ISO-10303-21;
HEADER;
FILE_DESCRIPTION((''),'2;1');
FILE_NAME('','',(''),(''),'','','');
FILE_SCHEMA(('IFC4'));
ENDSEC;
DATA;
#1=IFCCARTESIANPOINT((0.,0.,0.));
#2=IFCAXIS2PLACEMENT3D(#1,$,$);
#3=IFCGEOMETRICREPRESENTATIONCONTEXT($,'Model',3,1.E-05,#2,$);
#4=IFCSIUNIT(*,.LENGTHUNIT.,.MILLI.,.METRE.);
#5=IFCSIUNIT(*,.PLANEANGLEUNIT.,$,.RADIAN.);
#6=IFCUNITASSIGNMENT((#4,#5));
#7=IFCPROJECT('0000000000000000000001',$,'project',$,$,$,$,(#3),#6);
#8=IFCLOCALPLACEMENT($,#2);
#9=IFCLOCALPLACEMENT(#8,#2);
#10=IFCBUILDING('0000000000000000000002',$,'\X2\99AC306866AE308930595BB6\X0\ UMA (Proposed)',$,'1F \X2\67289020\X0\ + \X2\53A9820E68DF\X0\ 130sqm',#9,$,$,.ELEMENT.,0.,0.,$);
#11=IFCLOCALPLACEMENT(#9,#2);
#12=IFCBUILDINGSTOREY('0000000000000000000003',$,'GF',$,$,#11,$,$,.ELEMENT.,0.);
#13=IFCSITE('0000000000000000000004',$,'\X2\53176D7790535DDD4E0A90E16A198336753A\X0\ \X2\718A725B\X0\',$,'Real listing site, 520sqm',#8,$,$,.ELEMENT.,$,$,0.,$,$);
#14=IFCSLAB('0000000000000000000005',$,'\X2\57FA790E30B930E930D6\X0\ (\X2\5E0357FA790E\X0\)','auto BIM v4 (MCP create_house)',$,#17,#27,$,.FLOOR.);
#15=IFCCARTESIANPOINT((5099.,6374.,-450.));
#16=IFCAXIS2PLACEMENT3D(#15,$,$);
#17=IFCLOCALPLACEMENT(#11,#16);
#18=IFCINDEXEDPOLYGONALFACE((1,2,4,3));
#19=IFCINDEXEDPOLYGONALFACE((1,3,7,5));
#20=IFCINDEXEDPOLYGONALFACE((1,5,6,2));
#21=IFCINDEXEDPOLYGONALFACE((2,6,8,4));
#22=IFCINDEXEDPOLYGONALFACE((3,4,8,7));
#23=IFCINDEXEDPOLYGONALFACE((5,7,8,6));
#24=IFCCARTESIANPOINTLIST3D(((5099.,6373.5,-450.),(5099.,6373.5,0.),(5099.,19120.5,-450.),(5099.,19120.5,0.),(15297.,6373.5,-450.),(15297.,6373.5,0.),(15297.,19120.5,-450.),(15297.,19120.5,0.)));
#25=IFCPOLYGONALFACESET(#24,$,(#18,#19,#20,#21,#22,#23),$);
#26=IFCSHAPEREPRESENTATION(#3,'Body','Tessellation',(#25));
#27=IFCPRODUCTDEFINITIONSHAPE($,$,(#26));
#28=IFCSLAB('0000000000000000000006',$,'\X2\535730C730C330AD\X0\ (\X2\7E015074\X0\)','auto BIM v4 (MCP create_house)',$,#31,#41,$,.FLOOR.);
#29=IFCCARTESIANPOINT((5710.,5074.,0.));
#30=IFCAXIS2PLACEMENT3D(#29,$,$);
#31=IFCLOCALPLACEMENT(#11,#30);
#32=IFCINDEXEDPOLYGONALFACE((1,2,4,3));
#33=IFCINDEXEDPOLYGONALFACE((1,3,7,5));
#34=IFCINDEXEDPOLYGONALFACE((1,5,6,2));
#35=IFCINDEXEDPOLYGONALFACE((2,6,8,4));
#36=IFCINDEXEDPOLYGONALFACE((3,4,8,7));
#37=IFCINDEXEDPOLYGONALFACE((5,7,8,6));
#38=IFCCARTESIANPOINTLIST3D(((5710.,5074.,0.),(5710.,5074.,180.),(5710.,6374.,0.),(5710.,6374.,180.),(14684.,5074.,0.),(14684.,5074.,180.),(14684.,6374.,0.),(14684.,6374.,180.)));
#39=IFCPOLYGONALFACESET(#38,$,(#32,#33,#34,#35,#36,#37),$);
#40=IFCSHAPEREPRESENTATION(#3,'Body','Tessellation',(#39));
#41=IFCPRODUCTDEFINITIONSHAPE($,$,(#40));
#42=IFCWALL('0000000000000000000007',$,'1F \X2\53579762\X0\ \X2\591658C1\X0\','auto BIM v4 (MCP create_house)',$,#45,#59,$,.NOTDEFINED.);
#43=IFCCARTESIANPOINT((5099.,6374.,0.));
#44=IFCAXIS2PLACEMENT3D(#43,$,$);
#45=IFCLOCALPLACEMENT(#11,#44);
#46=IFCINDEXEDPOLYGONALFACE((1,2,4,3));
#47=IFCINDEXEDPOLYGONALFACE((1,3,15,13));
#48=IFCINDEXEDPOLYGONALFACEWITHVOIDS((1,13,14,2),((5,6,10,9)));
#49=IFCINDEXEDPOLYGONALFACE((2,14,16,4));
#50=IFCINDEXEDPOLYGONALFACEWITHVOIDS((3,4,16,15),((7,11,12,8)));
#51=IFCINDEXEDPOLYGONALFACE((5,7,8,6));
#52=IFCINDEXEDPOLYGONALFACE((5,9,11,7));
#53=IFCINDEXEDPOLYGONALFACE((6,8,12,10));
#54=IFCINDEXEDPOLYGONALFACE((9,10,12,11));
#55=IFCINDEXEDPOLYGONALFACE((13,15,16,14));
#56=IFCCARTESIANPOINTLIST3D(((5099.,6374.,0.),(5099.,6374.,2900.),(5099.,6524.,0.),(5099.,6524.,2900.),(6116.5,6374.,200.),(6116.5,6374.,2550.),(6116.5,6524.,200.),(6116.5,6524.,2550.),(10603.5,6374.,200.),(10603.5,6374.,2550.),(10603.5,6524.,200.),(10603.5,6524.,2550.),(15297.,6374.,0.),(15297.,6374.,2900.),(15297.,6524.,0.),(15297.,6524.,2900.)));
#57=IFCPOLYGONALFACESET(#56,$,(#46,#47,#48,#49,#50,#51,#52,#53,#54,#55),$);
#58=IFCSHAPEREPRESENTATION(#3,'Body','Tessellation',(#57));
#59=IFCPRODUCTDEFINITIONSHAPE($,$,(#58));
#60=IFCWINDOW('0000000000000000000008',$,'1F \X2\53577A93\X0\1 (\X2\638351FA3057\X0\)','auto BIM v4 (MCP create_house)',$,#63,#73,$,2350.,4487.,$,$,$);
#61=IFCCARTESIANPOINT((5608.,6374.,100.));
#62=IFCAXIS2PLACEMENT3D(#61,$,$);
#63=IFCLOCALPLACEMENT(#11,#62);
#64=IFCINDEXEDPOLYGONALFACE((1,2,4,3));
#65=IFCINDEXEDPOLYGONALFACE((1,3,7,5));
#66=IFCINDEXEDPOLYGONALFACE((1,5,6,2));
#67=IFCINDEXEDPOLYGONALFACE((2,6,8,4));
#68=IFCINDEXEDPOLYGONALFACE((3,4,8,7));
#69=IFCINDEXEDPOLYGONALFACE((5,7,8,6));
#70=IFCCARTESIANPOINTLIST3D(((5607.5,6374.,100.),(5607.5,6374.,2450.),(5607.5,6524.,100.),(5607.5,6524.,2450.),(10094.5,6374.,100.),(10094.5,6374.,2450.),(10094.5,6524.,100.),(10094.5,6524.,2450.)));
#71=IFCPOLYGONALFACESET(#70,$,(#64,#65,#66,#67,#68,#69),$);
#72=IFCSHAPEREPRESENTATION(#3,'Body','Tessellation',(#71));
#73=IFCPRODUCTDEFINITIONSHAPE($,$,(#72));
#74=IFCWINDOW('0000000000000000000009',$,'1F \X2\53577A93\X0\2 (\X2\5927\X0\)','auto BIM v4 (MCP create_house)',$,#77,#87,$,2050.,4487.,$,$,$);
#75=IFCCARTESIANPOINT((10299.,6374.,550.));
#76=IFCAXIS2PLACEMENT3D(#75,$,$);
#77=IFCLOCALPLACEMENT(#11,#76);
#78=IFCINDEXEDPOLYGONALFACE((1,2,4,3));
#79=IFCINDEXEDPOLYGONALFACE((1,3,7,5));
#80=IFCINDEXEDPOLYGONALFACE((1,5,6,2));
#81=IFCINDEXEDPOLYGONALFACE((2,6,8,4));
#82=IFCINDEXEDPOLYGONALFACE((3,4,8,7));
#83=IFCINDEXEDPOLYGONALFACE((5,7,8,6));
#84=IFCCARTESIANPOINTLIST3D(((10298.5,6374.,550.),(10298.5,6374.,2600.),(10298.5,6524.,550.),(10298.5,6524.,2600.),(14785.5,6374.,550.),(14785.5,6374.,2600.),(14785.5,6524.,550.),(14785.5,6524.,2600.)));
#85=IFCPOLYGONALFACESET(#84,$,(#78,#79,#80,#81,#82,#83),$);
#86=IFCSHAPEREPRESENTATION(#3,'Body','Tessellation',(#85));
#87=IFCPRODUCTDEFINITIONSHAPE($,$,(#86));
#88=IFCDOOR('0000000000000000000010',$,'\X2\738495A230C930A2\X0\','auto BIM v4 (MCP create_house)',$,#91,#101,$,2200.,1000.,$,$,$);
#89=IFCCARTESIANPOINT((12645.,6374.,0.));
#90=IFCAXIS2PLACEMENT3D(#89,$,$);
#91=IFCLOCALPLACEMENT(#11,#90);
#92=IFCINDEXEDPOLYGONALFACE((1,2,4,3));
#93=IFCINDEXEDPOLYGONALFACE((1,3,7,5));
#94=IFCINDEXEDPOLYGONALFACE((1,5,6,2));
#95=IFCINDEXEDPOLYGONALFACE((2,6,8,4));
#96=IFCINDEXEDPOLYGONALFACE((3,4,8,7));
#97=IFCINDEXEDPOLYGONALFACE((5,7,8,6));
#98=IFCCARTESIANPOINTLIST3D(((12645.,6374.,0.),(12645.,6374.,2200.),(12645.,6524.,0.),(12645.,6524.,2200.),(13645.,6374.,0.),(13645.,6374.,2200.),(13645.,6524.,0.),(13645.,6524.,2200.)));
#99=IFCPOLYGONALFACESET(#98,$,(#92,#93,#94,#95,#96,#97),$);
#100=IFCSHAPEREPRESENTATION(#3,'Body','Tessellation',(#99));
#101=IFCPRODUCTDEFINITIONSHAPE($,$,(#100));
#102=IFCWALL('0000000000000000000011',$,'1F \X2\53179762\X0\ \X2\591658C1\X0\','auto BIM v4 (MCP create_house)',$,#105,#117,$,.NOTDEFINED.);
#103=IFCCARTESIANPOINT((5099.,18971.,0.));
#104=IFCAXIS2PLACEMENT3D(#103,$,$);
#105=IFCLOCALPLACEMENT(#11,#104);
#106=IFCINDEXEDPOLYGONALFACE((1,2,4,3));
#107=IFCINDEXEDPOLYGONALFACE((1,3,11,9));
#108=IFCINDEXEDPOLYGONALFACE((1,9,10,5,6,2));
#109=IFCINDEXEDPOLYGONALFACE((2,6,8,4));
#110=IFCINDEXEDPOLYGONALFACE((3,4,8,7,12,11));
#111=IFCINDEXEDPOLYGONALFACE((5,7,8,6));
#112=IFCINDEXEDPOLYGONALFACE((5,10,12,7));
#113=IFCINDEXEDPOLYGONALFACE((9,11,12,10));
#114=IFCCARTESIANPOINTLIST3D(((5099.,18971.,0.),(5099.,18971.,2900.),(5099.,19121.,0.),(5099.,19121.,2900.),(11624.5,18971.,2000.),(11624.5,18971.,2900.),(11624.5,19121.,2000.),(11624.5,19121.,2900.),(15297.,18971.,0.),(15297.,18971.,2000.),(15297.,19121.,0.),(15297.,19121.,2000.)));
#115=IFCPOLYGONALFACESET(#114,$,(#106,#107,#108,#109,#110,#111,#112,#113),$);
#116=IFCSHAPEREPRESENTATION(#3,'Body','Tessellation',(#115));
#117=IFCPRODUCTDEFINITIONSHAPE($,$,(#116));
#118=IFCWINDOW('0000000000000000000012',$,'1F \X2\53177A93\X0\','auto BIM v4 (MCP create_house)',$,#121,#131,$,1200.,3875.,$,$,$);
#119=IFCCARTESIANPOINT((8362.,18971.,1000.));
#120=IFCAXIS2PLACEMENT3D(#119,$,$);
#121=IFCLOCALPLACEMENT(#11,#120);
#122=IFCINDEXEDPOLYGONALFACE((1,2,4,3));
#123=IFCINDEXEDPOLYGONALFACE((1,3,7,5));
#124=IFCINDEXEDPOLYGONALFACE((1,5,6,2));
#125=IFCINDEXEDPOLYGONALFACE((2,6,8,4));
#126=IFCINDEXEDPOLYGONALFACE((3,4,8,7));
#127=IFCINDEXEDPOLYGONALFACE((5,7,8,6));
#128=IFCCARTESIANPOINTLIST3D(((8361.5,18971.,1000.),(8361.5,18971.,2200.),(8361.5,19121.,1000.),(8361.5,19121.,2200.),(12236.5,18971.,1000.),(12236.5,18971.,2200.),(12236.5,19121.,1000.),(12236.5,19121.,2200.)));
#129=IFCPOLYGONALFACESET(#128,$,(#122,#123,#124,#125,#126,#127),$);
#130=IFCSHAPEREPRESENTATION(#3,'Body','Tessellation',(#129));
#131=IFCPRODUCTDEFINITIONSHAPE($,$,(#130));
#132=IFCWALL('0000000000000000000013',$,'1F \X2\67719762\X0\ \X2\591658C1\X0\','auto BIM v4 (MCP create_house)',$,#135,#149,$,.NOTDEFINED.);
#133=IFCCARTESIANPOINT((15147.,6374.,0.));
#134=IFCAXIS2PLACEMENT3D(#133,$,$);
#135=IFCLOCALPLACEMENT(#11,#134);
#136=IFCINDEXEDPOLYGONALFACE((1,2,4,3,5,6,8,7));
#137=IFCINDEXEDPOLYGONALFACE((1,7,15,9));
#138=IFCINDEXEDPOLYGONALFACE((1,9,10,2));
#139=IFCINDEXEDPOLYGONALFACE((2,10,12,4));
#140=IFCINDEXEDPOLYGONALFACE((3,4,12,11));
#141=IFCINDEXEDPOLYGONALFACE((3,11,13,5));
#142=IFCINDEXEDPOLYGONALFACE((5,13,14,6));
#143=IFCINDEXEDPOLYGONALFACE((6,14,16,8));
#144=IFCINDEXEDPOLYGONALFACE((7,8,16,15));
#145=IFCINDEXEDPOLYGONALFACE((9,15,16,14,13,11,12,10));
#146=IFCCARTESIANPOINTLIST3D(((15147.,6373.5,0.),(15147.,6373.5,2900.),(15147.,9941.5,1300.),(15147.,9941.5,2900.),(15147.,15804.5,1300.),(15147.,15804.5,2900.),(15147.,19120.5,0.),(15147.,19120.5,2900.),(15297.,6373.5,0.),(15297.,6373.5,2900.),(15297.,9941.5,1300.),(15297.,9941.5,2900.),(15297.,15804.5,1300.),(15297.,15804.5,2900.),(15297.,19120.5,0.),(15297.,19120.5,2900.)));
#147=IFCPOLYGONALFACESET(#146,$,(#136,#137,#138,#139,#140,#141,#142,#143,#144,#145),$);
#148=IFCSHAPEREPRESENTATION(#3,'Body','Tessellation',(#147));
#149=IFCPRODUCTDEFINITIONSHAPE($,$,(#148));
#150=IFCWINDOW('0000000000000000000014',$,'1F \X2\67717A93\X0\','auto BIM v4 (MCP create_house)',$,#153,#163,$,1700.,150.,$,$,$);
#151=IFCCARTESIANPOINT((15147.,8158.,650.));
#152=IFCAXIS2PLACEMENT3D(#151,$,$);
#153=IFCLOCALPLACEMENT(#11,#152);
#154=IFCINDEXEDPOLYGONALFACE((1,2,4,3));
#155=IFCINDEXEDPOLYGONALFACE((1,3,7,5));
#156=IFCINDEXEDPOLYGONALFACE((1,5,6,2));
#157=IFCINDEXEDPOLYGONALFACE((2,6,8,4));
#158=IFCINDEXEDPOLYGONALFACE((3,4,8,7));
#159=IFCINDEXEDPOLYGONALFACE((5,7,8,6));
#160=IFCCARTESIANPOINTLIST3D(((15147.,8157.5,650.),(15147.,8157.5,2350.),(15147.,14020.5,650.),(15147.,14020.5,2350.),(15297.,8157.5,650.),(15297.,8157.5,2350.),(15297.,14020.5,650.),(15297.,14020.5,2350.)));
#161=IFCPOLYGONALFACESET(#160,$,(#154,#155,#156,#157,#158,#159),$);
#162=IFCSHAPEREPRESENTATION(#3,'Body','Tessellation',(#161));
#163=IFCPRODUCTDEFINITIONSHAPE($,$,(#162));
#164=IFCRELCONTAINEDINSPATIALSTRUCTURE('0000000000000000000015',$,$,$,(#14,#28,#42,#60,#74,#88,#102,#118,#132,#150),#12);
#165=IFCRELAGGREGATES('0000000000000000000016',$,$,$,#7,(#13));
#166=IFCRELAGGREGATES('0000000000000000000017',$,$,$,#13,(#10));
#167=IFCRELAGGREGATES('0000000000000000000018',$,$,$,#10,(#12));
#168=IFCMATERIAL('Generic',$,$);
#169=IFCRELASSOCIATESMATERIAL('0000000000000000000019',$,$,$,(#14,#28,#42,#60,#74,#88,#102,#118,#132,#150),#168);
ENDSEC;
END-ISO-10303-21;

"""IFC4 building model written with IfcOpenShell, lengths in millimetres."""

from ifc_helpers import new_model, si_unit, frame, frame_2d, origin, place, context, project, spatial, rectangle, extrude, material, element, fill, save


model = new_model("IFC4")

# Units and contexts
model_context = context("Model", 3, precision=1e-05, world=origin())
ifc_project = project(units=[si_unit("LENGTHUNIT", "METRE", prefix="MILLI"), si_unit("PLANEANGLEUNIT", "RADIAN")], contexts=[model_context])

# Site, building, storey
site_placement = place(None, origin())
site = spatial("IfcSite", under=ifc_project, at=site_placement, Name="北海道川上郡標茶町 熊牛", ObjectType="Real listing site, 520sqm", CompositionType="ELEMENT", RefElevation=0.0)
building_placement = place(site_placement, origin())
building = spatial("IfcBuilding", under=site, at=building_placement, Name="馬と暮らす家 UMA (Proposed)", ObjectType="1F 木造 + 厩舎棟 130sqm", CompositionType="ELEMENT", ElevationOfRefHeight=0.0, ElevationOfTerrain=0.0)
storey_placement = place(building_placement, origin())
storey = spatial("IfcBuildingStorey", under=building, at=storey_placement, Name="GF", CompositionType="ELEMENT", Elevation=0.0)

# Slabs
ifc_material = material(Name="Generic")
slab_1_placement = place(storey_placement, frame((5099.0, 6374.0, -450.0)))
element("IfcSlab", 1, at=slab_1_placement, inside=storey, material=ifc_material, Name="基礎スラブ (布基礎)", Description="auto BIM v4 (MCP create_house)", PredefinedType="FLOOR", context=model_context, shape_type="SweptSolid", body=[
    extrude(rectangle(XDim=10198.0, YDim=12747.0, at=frame_2d((5099.0, 6373.0))), frame((5099.0, 6374.0, -450.0)), (0.0, 0.0, 1.0), 450.0),
])
slab_2_placement = place(storey_placement, frame((5710.0, 5074.0, 0.0)))
element("IfcSlab", 2, at=slab_2_placement, inside=storey, material=ifc_material, Name="南デッキ (縁側)", Description="auto BIM v4 (MCP create_house)", PredefinedType="FLOOR", context=model_context, shape_type="SweptSolid", body=[
    extrude(rectangle(XDim=8974.0, YDim=1300.0, at=frame_2d((4487.0, 650.0))), frame((5710.0, 5074.0, 0.0)), (0.0, 0.0, 1.0), 180.0),
])

# Wall, openings, windows, door
wall_1_placement = place(storey_placement, frame((5099.0, 6374.0, 0.0)))
wall_1 = element("IfcWall", 3, at=wall_1_placement, inside=storey, material=ifc_material, Name="1F 南面 外壁", Description="auto BIM v4 (MCP create_house)", PredefinedType="NOTDEFINED", context=model_context, shape_type="SweptSolid", body=[
    extrude(rectangle(XDim=10198.0, YDim=150.0, at=frame_2d((5099.0, 75.0))), frame((5099.0, 6374.0, 0.0)), (0.0, 0.0, 1.0), 2900.0),
])
opening_1_placement = place(storey_placement, frame((5608.0, 6374.0, 100.0)))
opening_1 = element("IfcOpeningElement", 4, at=opening_1_placement, cuts=wall_1, PredefinedType="NOTDEFINED", context=model_context, shape_type="SweptSolid", body=[
    extrude(rectangle(XDim=4487.0, YDim=150.0, at=frame_2d((2243.0, 75.0))), frame((5608.0, 6374.0, 100.0)), (0.0, 0.0, 1.0), 2350.0),
])
opening_2_placement = place(storey_placement, frame((10299.0, 6374.0, 550.0)))
opening_2 = element("IfcOpeningElement", 5, at=opening_2_placement, cuts=wall_1, PredefinedType="NOTDEFINED", context=model_context, shape_type="SweptSolid", body=[
    extrude(rectangle(XDim=4487.0, YDim=150.0, at=frame_2d((2243.0, 75.0))), frame((10299.0, 6374.0, 550.0)), (0.0, 0.0, 1.0), 2050.0),
])
opening_3_placement = place(storey_placement, frame((12645.0, 6374.0, 0.0)))
opening_3 = element("IfcOpeningElement", 6, at=opening_3_placement, cuts=wall_1, PredefinedType="NOTDEFINED", context=model_context, shape_type="SweptSolid", body=[
    extrude(rectangle(XDim=1000.0, YDim=150.0, at=frame_2d((500.0, 75.0))), frame((12645.0, 6374.0, 0.0)), (0.0, 0.0, 1.0), 2200.0),
])
window_1_placement = place(storey_placement, frame((5608.0, 6374.0, 100.0)))
window_1 = element("IfcWindow", 7, at=window_1_placement, inside=storey, material=ifc_material, Name="1F 南窓1 (掃出し)", Description="auto BIM v4 (MCP create_house)", OverallHeight=2350.0, OverallWidth=4487.0, context=model_context, shape_type="SweptSolid", body=[
    extrude(rectangle(XDim=4487.0, YDim=150.0, at=frame_2d((2243.0, 75.0))), frame((5608.0, 6374.0, 100.0)), (0.0, 0.0, 1.0), 2350.0),
])
fill(opening_1, window_1)
window_2_placement = place(storey_placement, frame((10299.0, 6374.0, 550.0)))
window_2 = element("IfcWindow", 8, at=window_2_placement, inside=storey, material=ifc_material, Name="1F 南窓2 (大)", Description="auto BIM v4 (MCP create_house)", OverallHeight=2050.0, OverallWidth=4487.0, context=model_context, shape_type="SweptSolid", body=[
    extrude(rectangle(XDim=4487.0, YDim=150.0, at=frame_2d((2243.0, 75.0))), frame((10299.0, 6374.0, 550.0)), (0.0, 0.0, 1.0), 2050.0),
])
fill(opening_2, window_2)
door_placement = place(storey_placement, frame((12645.0, 6374.0, 0.0)))
door = element("IfcDoor", 9, at=door_placement, inside=storey, material=ifc_material, Name="玄関ドア", Description="auto BIM v4 (MCP create_house)", OverallHeight=2200.0, OverallWidth=1000.0, context=model_context, shape_type="SweptSolid", body=[
    extrude(rectangle(XDim=1000.0, YDim=150.0, at=frame_2d((500.0, 75.0))), frame((12645.0, 6374.0, 0.0)), (0.0, 0.0, 1.0), 2200.0),
])
fill(opening_3, door)

# Walls, openings, windows
wall_2_placement = place(storey_placement, frame((5099.0, 18971.0, 0.0)))
wall_2 = element("IfcWall", 10, at=wall_2_placement, inside=storey, material=ifc_material, Name="1F 北面 外壁", Description="auto BIM v4 (MCP create_house)", PredefinedType="NOTDEFINED", context=model_context, shape_type="SweptSolid", body=[
    extrude(rectangle(XDim=10198.0, YDim=150.0, at=frame_2d((5099.0, 75.0))), frame((5099.0, 18971.0, 0.0)), (0.0, 0.0, 1.0), 2900.0),
])
opening_4_placement = place(storey_placement, frame((8362.0, 18971.0, 1000.0)))
opening_4 = element("IfcOpeningElement", 11, at=opening_4_placement, cuts=wall_2, PredefinedType="NOTDEFINED", context=model_context, shape_type="SweptSolid", body=[
    extrude(rectangle(XDim=3875.0, YDim=150.0, at=frame_2d((1937.0, 75.0))), frame((8362.0, 18971.0, 1000.0)), (0.0, 0.0, 1.0), 1200.0),
])
window_3_placement = place(storey_placement, frame((8362.0, 18971.0, 1000.0)))
window_3 = element("IfcWindow", 12, at=window_3_placement, inside=storey, material=ifc_material, Name="1F 北窓", Description="auto BIM v4 (MCP create_house)", OverallHeight=1200.0, OverallWidth=3875.0, context=model_context, shape_type="SweptSolid", body=[
    extrude(rectangle(XDim=3875.0, YDim=150.0, at=frame_2d((1937.0, 75.0))), frame((8362.0, 18971.0, 1000.0)), (0.0, 0.0, 1.0), 1200.0),
])
fill(opening_4, window_3)
wall_3_placement = place(storey_placement, frame((15147.0, 6374.0, 0.0)))
wall_3 = element("IfcWall", 13, at=wall_3_placement, inside=storey, material=ifc_material, Name="1F 東面 外壁", Description="auto BIM v4 (MCP create_house)", PredefinedType="NOTDEFINED", context=model_context, shape_type="SweptSolid", body=[
    extrude(rectangle(XDim=150.0, YDim=12747.0, at=frame_2d((75.0, 6373.0))), frame((15147.0, 6374.0, 0.0)), (0.0, 0.0, 1.0), 2900.0),
])
opening_5_placement = place(storey_placement, frame((15147.0, 8158.0, 650.0)))
opening_5 = element("IfcOpeningElement", 14, at=opening_5_placement, cuts=wall_3, PredefinedType="NOTDEFINED", context=model_context, shape_type="SweptSolid", body=[
    extrude(rectangle(XDim=150.0, YDim=5863.0, at=frame_2d((75.0, 2931.0))), frame((15147.0, 8158.0, 650.0)), (0.0, 0.0, 1.0), 1700.0),
])
window_4_placement = place(storey_placement, frame((15147.0, 8158.0, 650.0)))
window_4 = element("IfcWindow", 15, at=window_4_placement, inside=storey, material=ifc_material, Name="1F 東窓", Description="auto BIM v4 (MCP create_house)", OverallHeight=1700.0, OverallWidth=150.0, context=model_context, shape_type="SweptSolid", body=[
    extrude(rectangle(XDim=150.0, YDim=5863.0, at=frame_2d((75.0, 2931.0))), frame((15147.0, 8158.0, 650.0)), (0.0, 0.0, 1.0), 1700.0),
])
fill(opening_5, window_4)

save(model, "model.ifc")
